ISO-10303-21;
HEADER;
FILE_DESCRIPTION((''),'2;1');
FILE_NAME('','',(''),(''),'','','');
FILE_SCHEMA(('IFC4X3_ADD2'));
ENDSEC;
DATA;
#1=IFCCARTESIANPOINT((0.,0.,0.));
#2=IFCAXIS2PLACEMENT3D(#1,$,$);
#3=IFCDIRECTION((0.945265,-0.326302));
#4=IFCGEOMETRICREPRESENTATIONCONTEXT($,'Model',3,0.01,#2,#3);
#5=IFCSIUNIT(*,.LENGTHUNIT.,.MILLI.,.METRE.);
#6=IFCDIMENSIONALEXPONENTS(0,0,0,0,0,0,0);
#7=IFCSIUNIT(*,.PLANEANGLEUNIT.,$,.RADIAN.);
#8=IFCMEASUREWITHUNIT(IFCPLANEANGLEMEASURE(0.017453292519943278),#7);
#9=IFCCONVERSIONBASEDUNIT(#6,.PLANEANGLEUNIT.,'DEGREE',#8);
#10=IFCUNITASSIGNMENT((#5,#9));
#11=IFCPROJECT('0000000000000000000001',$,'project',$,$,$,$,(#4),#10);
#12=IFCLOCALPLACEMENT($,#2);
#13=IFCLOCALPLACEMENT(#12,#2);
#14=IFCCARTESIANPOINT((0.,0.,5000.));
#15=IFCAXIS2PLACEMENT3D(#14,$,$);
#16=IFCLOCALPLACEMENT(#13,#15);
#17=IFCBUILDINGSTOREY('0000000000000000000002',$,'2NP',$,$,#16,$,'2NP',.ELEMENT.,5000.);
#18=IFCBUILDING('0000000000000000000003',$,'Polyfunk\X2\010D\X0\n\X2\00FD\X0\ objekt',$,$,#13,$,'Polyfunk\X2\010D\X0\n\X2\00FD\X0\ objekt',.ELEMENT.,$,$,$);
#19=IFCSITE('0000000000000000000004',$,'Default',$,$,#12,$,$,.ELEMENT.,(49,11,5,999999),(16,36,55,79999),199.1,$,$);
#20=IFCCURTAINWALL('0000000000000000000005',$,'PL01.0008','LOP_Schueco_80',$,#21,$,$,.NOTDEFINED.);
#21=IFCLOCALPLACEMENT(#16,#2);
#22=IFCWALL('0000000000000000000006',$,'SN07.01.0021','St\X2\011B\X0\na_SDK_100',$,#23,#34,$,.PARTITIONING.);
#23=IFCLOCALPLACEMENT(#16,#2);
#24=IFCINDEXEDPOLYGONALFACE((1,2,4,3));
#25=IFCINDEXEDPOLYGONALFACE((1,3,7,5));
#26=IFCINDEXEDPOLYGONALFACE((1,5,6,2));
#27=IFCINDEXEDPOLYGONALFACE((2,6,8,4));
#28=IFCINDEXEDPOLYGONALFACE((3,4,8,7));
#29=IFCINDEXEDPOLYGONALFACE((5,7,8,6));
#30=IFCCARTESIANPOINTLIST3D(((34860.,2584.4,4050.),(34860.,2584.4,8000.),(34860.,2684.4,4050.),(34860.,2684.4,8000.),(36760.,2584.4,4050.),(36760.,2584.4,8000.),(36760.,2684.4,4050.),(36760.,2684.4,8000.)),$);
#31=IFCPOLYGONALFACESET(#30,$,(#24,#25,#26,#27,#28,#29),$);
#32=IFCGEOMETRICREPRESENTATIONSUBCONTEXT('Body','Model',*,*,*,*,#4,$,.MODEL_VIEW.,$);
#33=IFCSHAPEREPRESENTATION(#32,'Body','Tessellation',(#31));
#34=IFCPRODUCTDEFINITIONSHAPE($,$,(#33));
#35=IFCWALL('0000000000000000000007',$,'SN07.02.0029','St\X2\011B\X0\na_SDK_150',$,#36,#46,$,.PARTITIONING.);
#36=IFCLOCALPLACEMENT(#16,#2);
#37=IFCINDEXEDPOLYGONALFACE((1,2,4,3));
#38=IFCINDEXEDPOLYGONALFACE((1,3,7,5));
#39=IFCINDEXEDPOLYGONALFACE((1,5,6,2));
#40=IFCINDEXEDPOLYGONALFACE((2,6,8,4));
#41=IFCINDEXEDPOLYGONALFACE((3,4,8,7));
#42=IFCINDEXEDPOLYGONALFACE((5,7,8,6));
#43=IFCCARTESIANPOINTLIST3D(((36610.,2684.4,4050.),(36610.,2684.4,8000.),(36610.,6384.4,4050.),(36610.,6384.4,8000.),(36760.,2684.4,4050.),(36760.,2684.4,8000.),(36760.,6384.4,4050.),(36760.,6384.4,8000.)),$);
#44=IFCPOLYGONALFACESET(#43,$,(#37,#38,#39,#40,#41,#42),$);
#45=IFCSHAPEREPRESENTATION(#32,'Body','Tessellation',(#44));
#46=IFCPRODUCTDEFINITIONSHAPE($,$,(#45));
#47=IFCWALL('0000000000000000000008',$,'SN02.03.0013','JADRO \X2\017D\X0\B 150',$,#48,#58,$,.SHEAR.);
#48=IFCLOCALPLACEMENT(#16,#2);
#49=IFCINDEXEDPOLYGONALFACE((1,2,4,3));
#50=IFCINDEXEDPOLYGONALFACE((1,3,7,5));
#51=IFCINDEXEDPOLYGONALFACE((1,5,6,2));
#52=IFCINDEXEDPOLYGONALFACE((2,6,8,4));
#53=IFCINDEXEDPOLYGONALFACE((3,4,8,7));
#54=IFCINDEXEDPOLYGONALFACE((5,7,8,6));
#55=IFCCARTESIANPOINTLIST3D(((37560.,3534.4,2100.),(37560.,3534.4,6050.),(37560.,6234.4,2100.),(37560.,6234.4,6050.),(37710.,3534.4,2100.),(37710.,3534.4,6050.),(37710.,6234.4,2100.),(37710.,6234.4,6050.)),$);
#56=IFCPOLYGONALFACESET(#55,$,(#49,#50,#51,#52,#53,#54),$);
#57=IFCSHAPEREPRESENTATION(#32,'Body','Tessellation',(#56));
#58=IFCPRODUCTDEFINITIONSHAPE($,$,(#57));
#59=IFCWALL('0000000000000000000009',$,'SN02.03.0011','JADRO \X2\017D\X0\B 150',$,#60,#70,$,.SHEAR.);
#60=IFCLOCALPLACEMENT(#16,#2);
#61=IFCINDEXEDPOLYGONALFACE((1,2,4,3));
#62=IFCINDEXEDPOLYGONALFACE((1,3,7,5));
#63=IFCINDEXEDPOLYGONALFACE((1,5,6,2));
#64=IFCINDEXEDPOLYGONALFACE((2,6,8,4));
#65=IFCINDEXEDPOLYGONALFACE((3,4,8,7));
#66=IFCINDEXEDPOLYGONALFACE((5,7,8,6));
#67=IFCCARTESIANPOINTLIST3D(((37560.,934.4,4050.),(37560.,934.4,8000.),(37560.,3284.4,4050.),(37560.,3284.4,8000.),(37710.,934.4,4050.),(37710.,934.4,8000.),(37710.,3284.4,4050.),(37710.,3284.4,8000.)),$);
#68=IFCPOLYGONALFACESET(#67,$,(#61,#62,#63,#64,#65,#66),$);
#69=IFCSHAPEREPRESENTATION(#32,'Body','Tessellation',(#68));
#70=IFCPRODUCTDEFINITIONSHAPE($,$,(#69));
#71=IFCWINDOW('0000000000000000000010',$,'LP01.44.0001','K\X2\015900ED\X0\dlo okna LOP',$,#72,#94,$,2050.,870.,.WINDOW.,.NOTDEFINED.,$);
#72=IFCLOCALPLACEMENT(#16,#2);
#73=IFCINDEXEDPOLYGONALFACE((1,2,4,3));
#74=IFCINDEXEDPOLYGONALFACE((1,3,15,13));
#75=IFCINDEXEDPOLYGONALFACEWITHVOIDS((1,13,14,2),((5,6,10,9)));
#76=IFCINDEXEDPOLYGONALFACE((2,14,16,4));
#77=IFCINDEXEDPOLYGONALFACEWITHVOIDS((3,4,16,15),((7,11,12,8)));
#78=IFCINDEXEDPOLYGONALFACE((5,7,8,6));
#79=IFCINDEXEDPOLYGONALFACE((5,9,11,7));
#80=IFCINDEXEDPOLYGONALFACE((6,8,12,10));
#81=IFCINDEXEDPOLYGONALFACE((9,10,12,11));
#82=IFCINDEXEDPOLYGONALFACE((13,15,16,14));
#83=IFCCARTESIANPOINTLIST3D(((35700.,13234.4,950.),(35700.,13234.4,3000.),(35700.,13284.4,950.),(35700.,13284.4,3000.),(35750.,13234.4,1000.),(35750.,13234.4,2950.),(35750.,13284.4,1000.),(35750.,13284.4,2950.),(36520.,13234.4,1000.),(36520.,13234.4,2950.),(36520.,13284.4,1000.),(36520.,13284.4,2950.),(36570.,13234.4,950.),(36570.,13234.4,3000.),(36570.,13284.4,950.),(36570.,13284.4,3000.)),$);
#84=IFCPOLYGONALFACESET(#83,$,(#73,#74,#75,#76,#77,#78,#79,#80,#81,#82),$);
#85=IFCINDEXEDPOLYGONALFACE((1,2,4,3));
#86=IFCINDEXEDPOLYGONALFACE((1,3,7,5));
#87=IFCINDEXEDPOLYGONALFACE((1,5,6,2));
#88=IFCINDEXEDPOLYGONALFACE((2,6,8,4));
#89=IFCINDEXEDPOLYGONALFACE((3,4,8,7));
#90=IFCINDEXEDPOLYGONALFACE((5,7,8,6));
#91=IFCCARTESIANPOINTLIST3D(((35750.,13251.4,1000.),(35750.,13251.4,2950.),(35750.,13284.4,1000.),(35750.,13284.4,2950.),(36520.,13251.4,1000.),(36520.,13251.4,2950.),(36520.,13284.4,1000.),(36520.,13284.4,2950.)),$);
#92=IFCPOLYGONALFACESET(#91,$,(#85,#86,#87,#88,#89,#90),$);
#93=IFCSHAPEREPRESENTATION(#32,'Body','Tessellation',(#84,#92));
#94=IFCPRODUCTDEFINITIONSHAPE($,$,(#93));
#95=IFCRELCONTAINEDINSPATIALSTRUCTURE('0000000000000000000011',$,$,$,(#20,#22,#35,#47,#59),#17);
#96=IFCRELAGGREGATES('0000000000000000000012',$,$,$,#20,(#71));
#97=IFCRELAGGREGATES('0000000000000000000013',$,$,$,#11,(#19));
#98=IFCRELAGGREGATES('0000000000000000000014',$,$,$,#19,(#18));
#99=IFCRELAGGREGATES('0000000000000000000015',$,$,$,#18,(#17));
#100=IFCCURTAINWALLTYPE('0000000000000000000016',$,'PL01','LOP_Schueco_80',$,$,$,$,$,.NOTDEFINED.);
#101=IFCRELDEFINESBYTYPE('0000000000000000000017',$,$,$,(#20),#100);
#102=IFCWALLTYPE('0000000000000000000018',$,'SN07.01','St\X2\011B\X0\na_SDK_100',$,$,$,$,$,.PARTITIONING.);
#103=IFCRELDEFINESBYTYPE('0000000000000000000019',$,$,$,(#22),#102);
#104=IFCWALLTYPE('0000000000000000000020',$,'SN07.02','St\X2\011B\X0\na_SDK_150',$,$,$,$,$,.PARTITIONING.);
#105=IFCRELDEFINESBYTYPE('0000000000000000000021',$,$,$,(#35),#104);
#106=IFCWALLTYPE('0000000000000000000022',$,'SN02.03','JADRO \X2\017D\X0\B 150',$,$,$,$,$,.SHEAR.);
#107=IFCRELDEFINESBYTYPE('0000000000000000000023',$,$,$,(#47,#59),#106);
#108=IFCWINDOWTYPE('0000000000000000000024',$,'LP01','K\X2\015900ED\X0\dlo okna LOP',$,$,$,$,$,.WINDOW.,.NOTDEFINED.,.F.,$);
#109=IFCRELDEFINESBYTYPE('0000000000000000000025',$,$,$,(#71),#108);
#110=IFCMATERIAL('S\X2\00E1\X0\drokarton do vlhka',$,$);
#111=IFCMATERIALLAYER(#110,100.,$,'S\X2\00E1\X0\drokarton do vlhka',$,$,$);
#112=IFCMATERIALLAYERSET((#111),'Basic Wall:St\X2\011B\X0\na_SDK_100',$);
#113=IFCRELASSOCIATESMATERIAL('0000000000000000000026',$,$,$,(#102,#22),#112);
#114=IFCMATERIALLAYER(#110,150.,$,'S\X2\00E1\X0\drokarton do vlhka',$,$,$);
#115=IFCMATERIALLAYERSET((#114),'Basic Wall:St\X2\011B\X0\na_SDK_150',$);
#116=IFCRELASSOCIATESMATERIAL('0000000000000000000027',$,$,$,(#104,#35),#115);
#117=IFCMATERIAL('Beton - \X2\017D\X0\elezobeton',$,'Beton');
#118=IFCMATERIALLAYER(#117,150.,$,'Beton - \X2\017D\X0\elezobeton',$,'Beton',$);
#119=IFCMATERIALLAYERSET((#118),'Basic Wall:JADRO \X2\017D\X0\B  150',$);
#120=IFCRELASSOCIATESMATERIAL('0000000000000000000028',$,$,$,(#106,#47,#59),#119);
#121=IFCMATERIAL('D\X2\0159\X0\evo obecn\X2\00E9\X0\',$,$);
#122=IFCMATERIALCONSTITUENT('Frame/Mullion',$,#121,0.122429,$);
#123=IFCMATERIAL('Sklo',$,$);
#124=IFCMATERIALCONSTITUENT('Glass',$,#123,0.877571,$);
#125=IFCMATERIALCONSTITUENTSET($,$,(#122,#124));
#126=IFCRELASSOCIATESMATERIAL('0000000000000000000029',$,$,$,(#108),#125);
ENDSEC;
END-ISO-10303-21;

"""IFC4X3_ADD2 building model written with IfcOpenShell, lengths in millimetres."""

from ifc_helpers import new_model, entity, si_unit, converted_unit, direction, frame, frame_2d, origin, origin_2d_with_axis, place, context, subcontext, project, spatial, polyline, rectangle, outline, extrude, clip, bounded_halfspace, source, transform, mapped, material, layer, layer_set, constituent, constituent_set, type_object, type_shapes, element, aggregate, save


model = new_model("IFC4X3_ADD2")

# Units and contexts
model_context = context("Model", 3, precision=0.01, world=origin(), true_north=direction((0.945265, -0.326302)))
body_context = subcontext(model_context, "Body", "Model", "MODEL_VIEW")
ifc_project = project(units=[si_unit("LENGTHUNIT", "METRE", prefix="MILLI"), converted_unit("PLANEANGLEUNIT", "DEGREE", entity("IfcPlaneAngleMeasure", 0.017453292519943278), si_unit("PLANEANGLEUNIT", "RADIAN"), dimensions=[0, 0, 0, 0, 0, 0, 0])], contexts=[model_context])

# Site, building, storey
site_placement = place(None, origin())
site = spatial("IfcSite", under=ifc_project, at=site_placement, Name="Default", CompositionType="ELEMENT", RefLatitude=(49, 11, 5, 999999), RefLongitude=(16, 36, 55, 79999), RefElevation=199.1)
building_placement = place(site_placement, origin())
building = spatial("IfcBuilding", under=site, at=building_placement, Name="Polyfunkčný objekt", LongName="Polyfunkčný objekt", CompositionType="ELEMENT")
storey_placement = place(building_placement, frame((0.0, 0.0, 5000.0)))
storey = spatial("IfcBuildingStorey", under=building, at=storey_placement, Name="2NP", LongName="2NP", CompositionType="ELEMENT", Elevation=5000.0)

# Curtain wall
curtain_wall_type = type_object("IfcCurtainWallType", Name="PL01", Description="LOP_Schueco_80", PredefinedType="NOTDEFINED")
curtain_wall_placement = place(storey_placement, frame((0.0, 0.0, -5000.0)))
curtain_wall = element("IfcCurtainWall", 1, at=curtain_wall_placement, inside=storey, type_object=curtain_wall_type, Name="PL01.0008", Description="LOP_Schueco_80", PredefinedType="NOTDEFINED")
ifc_material_1 = material(Name="Sklo")

# Walls
ifc_material_2 = material(Name="Sádrokarton do vlhka")
ifc_layer_1 = layer(ifc_material_2, 100.0, Name="Sádrokarton do vlhka")
ifc_layer_set_1 = layer_set([ifc_layer_1], Name="Basic Wall:Stěna_SDK_100")
wall_type_1 = type_object("IfcWallType", Name="SN07.01", Description="Stěna_SDK_100", PredefinedType="PARTITIONING", material=ifc_layer_set_1)
wall_1_placement = place(storey_placement, frame((34860.0, 2634.4, 4050.0)))
element("IfcWall", 2, at=wall_1_placement, inside=storey, type_object=wall_type_1, material=ifc_layer_set_1, Name="SN07.01.0021", Description="Stěna_SDK_100", PredefinedType="PARTITIONING", context=body_context, shape_type="Clipping", body=[
    clip(clip(extrude(rectangle(XDim=1900.0, YDim=100.0, at=frame_2d((950.0, 0.0), x_axis=(-1.0, 0.0))), origin(), (0.0, 0.0, 1.0), 3950.0), bounded_halfspace(frame((1900.0, -50.0, 0.0), z_axis=(0.0, 0.0, 1.0), x_axis=(-1.0, 0.0, 0.0)), True, frame((1900.0, -50.0, 0.0)), polyline([(0.0, 0.0), (0.0, 100.0), (-150.0, 100.0), (-1900.0, 100.0), (-1900.0, 0.0), (-1800.0, 0.0), (0.0, 0.0)]))), bounded_halfspace(frame((0.0, -50.0, 3950.0), z_axis=(0.0, 0.0, -1.0), x_axis=(1.0, 0.0, 0.0)), True, frame((0.0, -50.0, 3950.0)), polyline([(0.0, 0.0), (100.0, 0.0), (1900.0, 0.0), (1900.0, 100.0), (1750.0, 100.0), (0.0, 100.0), (0.0, 0.0)]))),
])
ifc_layer_2 = layer(ifc_material_2, 150.0, Name="Sádrokarton do vlhka")
ifc_layer_set_2 = layer_set([ifc_layer_2], Name="Basic Wall:Stěna_SDK_150")
wall_type_2 = type_object("IfcWallType", Name="SN07.02", Description="Stěna_SDK_150", PredefinedType="PARTITIONING", material=ifc_layer_set_2)
wall_2_placement = place(storey_placement, frame((36685.0, 6384.4, 4050.0), z_axis=(0.0, 0.0, 1.0), x_axis=(0.0, -1.0, 0.0)))
element("IfcWall", 3, at=wall_2_placement, inside=storey, type_object=wall_type_2, material=ifc_layer_set_2, Name="SN07.02.0029", Description="Stěna_SDK_150", PredefinedType="PARTITIONING", context=body_context, shape_type="SweptSolid", body=[
    extrude(rectangle(XDim=3700.0, YDim=150.0, at=frame_2d((1850.0, 0.0), x_axis=(-1.0, 0.0))), origin(), (0.0, 0.0, 1.0), 3950.0),
])

# Walls
ifc_material_3 = material(Name="Beton - Železobeton", Category="Beton")
ifc_layer_3 = layer(ifc_material_3, 150.0, Name="Beton - Železobeton", Category="Beton")
ifc_layer_set_3 = layer_set([ifc_layer_3], Name="Basic Wall:JADRO ŽB  150")
wall_type_3 = type_object("IfcWallType", Name="SN02.03", Description="JADRO ŽB 150", PredefinedType="SHEAR", material=ifc_layer_set_3)
wall_3_placement = place(storey_placement, frame((37635.0, 6234.4, 2100.0), z_axis=(0.0, 0.0, 1.0), x_axis=(0.0, -1.0, 0.0)))
element("IfcWall", 4, at=wall_3_placement, inside=storey, type_object=wall_type_3, material=ifc_layer_set_3, Name="SN02.03.0013", Description="JADRO ŽB 150", PredefinedType="SHEAR", context=body_context, shape_type="SweptSolid", body=[
    extrude(rectangle(XDim=2700.0, YDim=150.0, at=frame_2d((1350.0, 0.0), x_axis=(-1.0, 0.0))), origin(), (0.0, 0.0, 1.0), 3950.0),
])
wall_4_placement = place(storey_placement, frame((37635.0, 3284.4, 4050.0), z_axis=(0.0, 0.0, 1.0), x_axis=(0.0, -1.0, 0.0)))
element("IfcWall", 5, at=wall_4_placement, inside=storey, type_object=wall_type_3, material=ifc_layer_set_3, Name="SN02.03.0011", Description="JADRO ŽB 150", PredefinedType="SHEAR", context=body_context, shape_type="SweptSolid", body=[
    extrude(rectangle(XDim=2350.0, YDim=150.0, at=frame_2d((1175.0, 0.0), x_axis=(-1.0, 0.0))), origin(), (0.0, 0.0, 1.0), 3950.0),
])

# Window
ifc_material_4 = material(Name="Dřevo obecné")
ifc_constituent_1 = constituent(ifc_material_4, Name="Frame/Mullion", fraction=0.122429)
ifc_constituent_2 = constituent(ifc_material_1, Name="Glass", fraction=0.877571)
ifc_constituent_set = constituent_set(constituents=[ifc_constituent_1, ifc_constituent_2])
window_type = type_object("IfcWindowType", Name="LP01", Description="Křídlo okna LOP", ParameterTakesPrecedence=False, PartitioningType="NOTDEFINED", PredefinedType="WINDOW", material=ifc_constituent_set)
shared_shape_1 = source(origin(), body_context, "Body", "SweptSolid", [
    extrude(outline(polyline([(-1025.0, -435.0), (1025.0, -435.0), (1025.0, 435.0), (-1025.0, 435.0), (-1025.0, -435.0)]), holes=[polyline([(-975.0, -385.0), (-975.0, 385.0), (975.0, 385.0), (975.0, -385.0), (-975.0, -385.0)])]), frame((0.0, 0.0, 1025.0), z_axis=(0.0, 1.0, 0.0), x_axis=(0.0, 0.0, -1.0)), (0.0, 0.0, 1.0), 50.0),
    extrude(rectangle(XDim=33.0, YDim=770.0, at=origin_2d_with_axis()), frame((0.0, 33.5, 50.0), z_axis=(0.0, 0.0, 1.0), x_axis=(0.0, -1.0, 0.0)), (0.0, 0.0, 1.0), 1950.0),
])
type_shapes(window_type, [shared_shape_1])
window_placement = place(curtain_wall_placement, frame((36135.0, 13234.4, 5950.0)))
window = element("IfcWindow", 6, at=window_placement, type_object=window_type, Name="LP01.44.0001", Description="Křídlo okna LOP", OverallHeight=2050.0, OverallWidth=870.0, PartitioningType="NOTDEFINED", PredefinedType="WINDOW", context=body_context, shape_type="MappedRepresentation", body=[
    mapped(shared_shape_1, transform((0.0, 0.0, 0.0), scale=1.0)),
])
aggregate(curtain_wall, [window])

save(model, "model.ifc")
